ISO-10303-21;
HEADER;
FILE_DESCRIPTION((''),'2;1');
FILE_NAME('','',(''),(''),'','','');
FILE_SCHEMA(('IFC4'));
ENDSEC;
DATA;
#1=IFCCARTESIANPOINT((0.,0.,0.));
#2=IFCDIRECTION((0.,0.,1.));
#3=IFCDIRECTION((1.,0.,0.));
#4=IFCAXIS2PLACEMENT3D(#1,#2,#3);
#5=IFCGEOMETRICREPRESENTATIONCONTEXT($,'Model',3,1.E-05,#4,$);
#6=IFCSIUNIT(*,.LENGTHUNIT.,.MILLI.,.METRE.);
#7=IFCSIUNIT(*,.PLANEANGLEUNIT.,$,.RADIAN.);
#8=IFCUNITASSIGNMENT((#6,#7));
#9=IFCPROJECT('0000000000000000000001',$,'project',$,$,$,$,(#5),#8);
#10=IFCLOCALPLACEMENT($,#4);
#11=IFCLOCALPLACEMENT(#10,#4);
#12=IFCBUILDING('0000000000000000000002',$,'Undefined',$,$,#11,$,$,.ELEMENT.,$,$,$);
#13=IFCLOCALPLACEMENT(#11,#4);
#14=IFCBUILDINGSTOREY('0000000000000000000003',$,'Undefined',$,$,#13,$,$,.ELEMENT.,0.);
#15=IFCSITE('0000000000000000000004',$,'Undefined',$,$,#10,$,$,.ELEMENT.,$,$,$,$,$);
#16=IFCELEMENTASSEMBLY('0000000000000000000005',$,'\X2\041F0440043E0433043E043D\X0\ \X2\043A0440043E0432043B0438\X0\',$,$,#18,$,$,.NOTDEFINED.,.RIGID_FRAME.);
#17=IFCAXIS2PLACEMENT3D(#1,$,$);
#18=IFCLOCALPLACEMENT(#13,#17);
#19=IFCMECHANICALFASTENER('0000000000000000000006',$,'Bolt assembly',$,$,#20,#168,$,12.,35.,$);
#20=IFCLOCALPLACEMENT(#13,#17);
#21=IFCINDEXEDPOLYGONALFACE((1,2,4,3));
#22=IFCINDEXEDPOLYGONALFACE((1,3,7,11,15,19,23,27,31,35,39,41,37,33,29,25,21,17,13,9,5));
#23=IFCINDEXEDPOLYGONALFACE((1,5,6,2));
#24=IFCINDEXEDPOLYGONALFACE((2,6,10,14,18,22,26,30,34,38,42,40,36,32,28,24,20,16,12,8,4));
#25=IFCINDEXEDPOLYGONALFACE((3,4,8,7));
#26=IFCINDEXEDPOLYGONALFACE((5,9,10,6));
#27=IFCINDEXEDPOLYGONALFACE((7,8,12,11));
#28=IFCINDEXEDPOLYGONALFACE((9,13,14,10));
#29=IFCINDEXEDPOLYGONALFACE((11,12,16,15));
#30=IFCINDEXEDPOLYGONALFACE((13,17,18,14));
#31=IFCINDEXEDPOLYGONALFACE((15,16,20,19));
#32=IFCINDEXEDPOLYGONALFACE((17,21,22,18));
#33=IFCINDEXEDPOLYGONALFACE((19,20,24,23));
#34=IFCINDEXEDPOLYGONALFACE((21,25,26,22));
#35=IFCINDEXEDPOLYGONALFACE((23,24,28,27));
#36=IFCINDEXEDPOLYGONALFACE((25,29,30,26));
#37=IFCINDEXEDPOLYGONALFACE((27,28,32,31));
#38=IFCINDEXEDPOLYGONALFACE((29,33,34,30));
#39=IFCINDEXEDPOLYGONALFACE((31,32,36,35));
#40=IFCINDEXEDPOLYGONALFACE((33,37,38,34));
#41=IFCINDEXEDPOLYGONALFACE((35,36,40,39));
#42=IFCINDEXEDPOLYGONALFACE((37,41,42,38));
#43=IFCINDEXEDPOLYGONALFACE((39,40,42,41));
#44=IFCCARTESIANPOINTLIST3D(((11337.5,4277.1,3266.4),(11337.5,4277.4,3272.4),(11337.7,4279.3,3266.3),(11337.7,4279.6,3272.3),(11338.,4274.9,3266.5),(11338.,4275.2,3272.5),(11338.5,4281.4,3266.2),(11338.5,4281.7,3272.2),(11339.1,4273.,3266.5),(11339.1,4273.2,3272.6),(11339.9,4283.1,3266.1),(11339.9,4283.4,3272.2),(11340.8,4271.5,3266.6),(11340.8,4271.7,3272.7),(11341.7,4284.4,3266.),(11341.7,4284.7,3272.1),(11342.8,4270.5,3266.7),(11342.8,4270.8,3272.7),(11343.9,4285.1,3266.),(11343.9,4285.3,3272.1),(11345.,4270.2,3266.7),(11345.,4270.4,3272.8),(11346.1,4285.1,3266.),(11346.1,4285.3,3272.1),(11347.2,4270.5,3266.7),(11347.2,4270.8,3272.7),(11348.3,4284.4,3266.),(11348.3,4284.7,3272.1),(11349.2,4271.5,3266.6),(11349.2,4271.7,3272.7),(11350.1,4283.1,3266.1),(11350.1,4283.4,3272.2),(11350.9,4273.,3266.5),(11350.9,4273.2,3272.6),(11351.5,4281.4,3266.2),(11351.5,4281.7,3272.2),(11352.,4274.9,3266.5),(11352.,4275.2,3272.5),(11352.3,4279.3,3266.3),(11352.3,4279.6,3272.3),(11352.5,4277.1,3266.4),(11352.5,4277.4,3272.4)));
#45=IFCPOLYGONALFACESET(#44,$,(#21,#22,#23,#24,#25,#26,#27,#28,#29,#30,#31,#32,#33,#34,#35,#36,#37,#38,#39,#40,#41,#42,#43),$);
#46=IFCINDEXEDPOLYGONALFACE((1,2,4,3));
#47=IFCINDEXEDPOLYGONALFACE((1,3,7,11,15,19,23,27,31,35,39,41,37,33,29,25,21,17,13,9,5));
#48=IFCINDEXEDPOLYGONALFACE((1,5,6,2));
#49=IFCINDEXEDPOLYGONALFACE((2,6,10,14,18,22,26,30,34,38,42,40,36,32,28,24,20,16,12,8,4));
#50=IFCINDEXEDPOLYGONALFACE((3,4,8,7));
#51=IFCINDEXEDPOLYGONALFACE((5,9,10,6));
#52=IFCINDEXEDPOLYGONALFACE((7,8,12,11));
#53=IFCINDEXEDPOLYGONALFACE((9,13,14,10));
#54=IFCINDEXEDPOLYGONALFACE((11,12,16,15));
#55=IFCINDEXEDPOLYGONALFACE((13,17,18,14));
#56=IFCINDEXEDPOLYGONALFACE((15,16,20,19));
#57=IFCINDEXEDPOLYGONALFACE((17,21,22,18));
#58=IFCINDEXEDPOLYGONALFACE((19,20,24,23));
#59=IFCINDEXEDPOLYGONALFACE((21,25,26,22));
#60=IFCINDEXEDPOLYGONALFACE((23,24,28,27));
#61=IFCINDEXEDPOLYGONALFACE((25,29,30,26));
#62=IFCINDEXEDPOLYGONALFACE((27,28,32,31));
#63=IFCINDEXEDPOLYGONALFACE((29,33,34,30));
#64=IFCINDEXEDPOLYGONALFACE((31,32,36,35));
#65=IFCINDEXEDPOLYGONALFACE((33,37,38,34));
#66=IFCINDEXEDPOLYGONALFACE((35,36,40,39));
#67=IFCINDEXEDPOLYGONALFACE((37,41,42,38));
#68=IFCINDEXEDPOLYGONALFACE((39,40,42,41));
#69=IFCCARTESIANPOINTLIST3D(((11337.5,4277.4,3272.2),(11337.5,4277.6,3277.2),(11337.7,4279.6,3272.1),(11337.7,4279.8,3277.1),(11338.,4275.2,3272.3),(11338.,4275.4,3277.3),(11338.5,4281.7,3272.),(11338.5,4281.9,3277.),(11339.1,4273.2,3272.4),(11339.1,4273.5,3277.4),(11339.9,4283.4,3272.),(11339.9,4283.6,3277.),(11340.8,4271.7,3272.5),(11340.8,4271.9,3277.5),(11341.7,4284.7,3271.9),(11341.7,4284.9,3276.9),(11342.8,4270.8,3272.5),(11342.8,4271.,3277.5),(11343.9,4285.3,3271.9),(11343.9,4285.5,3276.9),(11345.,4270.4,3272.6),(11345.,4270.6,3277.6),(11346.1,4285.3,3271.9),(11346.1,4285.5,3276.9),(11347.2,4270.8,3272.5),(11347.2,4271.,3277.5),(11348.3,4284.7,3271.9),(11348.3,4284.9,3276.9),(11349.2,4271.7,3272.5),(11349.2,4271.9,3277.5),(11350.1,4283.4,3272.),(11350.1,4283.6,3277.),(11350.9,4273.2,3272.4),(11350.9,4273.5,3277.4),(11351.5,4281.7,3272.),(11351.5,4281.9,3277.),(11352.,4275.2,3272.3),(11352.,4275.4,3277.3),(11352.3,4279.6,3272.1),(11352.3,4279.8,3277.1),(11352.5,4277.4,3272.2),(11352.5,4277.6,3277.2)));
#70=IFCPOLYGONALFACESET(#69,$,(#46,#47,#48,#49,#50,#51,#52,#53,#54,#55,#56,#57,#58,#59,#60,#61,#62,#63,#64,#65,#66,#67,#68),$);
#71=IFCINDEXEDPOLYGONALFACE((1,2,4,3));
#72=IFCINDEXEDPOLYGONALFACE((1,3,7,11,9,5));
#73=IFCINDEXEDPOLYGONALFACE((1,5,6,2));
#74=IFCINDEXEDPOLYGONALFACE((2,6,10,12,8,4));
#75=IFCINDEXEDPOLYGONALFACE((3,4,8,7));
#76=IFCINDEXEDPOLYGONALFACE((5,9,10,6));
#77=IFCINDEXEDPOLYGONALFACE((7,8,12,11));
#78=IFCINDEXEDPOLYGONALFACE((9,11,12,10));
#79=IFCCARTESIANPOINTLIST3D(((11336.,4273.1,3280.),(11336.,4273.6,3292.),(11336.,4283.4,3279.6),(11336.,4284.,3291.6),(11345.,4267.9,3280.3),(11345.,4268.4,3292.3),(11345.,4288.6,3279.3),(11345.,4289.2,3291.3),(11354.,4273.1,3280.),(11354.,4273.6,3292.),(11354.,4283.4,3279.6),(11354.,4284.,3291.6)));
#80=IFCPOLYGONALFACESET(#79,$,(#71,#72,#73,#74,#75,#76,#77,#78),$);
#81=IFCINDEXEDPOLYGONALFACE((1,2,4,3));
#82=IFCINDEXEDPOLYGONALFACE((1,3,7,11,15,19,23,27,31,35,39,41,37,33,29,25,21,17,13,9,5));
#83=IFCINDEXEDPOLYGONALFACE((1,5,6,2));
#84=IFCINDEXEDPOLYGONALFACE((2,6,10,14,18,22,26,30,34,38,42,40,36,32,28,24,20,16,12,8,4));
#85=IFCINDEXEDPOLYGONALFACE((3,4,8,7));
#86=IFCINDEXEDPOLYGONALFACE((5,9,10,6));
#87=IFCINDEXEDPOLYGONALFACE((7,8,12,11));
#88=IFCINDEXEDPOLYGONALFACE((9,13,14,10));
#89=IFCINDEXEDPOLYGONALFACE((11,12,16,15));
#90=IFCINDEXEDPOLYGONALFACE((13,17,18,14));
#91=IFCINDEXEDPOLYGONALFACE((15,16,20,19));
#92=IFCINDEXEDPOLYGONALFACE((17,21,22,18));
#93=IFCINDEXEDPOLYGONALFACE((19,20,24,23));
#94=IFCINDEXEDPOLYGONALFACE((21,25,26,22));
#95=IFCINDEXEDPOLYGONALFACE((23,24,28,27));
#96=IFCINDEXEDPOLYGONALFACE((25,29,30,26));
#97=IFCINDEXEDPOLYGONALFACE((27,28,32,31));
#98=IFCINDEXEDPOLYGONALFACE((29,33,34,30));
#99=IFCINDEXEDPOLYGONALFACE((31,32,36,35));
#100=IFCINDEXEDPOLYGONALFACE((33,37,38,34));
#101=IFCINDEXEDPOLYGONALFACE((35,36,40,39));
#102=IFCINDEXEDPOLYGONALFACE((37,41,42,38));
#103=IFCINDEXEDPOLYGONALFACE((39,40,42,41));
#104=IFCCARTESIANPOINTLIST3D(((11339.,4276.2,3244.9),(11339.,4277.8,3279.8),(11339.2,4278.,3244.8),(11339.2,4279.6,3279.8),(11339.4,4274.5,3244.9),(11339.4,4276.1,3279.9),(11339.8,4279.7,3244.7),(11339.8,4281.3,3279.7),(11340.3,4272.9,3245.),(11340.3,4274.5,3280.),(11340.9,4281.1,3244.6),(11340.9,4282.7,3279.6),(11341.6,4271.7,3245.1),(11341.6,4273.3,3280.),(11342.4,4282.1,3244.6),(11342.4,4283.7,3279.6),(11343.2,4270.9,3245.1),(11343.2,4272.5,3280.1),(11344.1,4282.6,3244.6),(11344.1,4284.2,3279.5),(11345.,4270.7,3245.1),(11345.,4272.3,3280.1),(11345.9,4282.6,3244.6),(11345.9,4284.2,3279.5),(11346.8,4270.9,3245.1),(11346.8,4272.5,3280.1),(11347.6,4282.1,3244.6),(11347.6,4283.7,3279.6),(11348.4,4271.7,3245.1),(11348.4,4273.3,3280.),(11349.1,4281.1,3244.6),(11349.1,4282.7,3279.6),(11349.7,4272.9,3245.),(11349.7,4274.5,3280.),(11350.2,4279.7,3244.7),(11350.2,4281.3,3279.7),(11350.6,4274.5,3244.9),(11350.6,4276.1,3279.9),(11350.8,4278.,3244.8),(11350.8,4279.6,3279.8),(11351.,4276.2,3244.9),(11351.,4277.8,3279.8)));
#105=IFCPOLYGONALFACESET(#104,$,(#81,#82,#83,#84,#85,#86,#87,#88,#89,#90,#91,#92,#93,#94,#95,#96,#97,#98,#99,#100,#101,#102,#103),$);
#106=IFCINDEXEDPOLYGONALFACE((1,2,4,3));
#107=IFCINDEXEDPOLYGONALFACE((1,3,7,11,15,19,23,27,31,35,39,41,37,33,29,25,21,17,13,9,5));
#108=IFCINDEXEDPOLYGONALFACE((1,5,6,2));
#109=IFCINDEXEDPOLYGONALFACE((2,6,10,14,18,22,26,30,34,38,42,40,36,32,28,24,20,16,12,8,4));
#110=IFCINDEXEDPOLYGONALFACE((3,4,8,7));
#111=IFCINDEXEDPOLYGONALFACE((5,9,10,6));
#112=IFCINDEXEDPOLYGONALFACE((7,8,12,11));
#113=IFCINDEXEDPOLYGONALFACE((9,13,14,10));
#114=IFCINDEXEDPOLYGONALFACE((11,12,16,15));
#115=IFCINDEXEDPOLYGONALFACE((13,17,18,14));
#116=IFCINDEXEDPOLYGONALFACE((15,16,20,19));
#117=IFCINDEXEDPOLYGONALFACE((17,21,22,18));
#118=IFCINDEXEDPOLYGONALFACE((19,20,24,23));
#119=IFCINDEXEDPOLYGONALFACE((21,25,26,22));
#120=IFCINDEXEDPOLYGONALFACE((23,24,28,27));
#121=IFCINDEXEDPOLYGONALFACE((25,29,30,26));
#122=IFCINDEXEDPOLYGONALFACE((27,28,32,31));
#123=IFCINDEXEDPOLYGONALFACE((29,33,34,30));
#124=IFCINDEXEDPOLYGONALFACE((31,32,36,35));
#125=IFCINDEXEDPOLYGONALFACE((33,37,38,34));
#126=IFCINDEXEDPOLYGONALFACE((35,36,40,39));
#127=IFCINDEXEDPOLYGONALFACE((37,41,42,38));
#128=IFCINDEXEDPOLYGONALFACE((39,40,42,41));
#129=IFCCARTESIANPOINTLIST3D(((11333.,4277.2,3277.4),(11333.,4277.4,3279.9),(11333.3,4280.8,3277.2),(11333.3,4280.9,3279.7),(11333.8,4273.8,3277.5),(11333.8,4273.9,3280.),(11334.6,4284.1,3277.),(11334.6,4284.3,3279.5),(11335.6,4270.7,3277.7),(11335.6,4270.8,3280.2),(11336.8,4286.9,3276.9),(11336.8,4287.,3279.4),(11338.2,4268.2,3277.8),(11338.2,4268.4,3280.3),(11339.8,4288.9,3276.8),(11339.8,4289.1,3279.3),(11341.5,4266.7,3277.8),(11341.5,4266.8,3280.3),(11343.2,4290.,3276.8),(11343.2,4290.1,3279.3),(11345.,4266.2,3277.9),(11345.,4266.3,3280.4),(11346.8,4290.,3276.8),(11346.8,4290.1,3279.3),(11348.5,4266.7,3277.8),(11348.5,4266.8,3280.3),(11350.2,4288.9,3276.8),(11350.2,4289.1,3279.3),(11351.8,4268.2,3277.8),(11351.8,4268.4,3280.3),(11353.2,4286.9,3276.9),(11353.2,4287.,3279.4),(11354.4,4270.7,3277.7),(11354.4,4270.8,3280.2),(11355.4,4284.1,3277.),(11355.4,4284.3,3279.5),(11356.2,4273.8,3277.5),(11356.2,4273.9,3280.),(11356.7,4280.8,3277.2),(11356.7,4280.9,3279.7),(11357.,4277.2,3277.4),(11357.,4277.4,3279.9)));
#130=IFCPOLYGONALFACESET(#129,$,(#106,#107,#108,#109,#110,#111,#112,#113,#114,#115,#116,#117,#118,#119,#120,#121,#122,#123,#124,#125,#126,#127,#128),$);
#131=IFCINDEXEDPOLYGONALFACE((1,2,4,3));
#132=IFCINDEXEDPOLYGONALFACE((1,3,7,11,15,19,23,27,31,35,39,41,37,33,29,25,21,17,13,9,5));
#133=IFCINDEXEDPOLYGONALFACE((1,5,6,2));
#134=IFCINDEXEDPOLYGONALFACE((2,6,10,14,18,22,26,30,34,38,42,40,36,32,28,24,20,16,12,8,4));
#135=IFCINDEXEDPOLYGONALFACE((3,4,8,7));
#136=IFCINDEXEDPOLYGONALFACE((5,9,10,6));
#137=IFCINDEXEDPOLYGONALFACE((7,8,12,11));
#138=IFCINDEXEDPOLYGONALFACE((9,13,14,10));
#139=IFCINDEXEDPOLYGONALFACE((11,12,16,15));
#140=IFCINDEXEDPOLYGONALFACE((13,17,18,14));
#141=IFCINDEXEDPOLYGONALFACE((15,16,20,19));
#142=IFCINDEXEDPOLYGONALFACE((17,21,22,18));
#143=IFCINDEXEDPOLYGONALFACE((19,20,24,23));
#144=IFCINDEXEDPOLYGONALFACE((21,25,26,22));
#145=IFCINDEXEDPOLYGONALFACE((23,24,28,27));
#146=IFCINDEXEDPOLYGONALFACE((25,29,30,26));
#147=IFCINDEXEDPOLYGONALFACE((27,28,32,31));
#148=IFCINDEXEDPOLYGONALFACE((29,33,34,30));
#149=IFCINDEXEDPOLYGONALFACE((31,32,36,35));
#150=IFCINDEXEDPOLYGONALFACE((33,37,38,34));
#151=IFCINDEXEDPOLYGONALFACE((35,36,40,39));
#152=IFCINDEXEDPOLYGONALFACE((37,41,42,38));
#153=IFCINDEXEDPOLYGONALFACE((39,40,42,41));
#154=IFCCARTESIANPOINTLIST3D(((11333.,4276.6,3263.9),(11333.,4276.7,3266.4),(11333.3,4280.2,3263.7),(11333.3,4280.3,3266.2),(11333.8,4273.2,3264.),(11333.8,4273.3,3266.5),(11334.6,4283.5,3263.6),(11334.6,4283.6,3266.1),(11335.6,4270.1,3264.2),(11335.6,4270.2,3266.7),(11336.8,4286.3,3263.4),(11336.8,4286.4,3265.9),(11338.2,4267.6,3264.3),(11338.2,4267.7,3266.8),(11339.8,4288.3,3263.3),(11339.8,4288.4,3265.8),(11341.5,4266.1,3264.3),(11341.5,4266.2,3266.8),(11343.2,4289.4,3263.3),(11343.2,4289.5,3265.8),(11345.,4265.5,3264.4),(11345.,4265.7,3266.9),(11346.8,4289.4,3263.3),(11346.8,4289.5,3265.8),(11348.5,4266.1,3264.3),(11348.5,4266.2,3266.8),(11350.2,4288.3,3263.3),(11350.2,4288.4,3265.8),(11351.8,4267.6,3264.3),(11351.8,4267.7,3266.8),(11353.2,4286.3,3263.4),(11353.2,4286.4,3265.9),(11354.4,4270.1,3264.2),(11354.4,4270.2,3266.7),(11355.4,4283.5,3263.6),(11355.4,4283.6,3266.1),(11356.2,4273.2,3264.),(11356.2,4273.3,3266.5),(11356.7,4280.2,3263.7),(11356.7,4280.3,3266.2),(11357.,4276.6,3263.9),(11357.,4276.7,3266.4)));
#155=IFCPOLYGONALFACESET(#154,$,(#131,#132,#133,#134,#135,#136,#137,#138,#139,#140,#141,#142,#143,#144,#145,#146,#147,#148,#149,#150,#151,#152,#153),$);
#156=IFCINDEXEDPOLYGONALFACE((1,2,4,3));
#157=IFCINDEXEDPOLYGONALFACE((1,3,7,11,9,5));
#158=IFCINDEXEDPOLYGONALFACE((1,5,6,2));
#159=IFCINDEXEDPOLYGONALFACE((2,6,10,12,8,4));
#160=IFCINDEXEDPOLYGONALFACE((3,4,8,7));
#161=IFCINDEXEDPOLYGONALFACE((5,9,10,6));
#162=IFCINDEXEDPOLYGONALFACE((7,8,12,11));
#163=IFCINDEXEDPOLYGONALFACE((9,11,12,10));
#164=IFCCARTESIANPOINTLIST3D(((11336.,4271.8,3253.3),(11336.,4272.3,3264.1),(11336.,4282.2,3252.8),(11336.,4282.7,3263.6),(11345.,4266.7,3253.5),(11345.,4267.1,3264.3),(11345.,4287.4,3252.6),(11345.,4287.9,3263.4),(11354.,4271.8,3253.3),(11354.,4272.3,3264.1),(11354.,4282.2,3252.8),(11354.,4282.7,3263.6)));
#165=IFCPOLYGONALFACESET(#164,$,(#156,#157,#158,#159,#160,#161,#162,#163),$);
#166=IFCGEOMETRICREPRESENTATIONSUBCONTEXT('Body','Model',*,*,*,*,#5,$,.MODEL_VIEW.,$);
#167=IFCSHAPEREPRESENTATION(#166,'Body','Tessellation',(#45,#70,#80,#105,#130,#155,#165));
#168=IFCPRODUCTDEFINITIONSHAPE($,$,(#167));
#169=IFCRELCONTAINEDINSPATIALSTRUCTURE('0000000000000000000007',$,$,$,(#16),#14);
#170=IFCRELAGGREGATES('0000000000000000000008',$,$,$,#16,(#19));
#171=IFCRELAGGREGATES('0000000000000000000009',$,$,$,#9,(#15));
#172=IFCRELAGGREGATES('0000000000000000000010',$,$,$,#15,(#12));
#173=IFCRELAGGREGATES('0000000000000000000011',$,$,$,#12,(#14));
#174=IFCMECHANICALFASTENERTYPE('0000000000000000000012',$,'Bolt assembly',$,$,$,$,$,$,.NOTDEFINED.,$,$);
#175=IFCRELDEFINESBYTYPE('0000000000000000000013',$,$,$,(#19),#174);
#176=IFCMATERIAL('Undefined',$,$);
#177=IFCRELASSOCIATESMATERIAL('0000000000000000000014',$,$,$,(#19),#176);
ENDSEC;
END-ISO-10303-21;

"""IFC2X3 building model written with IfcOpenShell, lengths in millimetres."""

from ifc_helpers import new_model, si_unit, frame, origin_with_axes, origin_2d_with_axis, place, context, subcontext, project, spatial, polyline, circle, outline, extrude, source, transform, mapped, material, type_object, element, aggregate, save


model = new_model("IFC2X3")

# Units and contexts
model_context = context("Model", 3, precision=1e-05, world=origin_with_axes())
body_context = subcontext(model_context, "Body", "Model", "MODEL_VIEW")
ifc_project = project(units=[si_unit("LENGTHUNIT", "METRE", prefix="MILLI"), si_unit("PLANEANGLEUNIT", "RADIAN")], contexts=[model_context])

# Site, building, storey
site_placement = place(None, origin_with_axes())
site = spatial("IfcSite", under=ifc_project, at=site_placement, Name="Undefined", CompositionType="ELEMENT")
building_placement = place(site_placement, origin_with_axes())
building = spatial("IfcBuilding", under=site, at=building_placement, Name="Undefined", CompositionType="ELEMENT")
storey_placement = place(building_placement, origin_with_axes())
storey = spatial("IfcBuildingStorey", under=building, at=storey_placement, Name="Undefined", CompositionType="ELEMENT", Elevation=0.0)

# Element assembly
assembly_1_placement = place(storey_placement, origin_with_axes())
assembly_1 = element("IfcElementAssembly", 1, at=assembly_1_placement, inside=storey, Name="Прогон кровли", AssemblyPlace="NOTDEFINED", PredefinedType="RIGID_FRAME")

# Mechanical fastener
ifc_material_1 = material(Name="Undefined")
mechanical_fastener_type = type_object("IfcMechanicalFastenerType", Name="Bolt assembly")
shared_shape_1 = source(origin_with_axes(), body_context, "Body", "SweptSolid", [
    extrude(circle(Radius=7.5, at=origin_2d_with_axis()), frame((0.0, -0.1, 0.0), z_axis=(0.0, 1.0, 0.0), x_axis=(1.0, 0.0, 0.0)), (0.0, 0.0, 1.0), 6.1),
    extrude(circle(Radius=7.5, at=origin_2d_with_axis()), frame((0.0, -4.9, 0.0), z_axis=(0.0, 1.0, 0.0), x_axis=(1.0, 0.0, 0.0)), (0.0, 0.0, 1.0), 5.0),
    extrude(outline(polyline([(10.4, 0.0), (5.2, 9.0), (-5.2, 9.0), (-10.4, 0.0), (-5.2, -9.0), (5.2, -9.0), (10.4, 0.0)])), frame((0.0, -19.5, 0.0), z_axis=(0.0, 1.0, 0.0), x_axis=(1.0, 0.0, 0.0)), (0.0, 0.0, 1.0), 12.0),
    extrude(circle(Radius=6.0, at=origin_2d_with_axis()), frame((0.0, -7.5, 0.0), z_axis=(0.0, 1.0, 0.0), x_axis=(1.0, 0.0, 0.0)), (0.0, 0.0, 1.0), 35.0),
    extrude(circle(Radius=12.0, at=origin_2d_with_axis()), frame((0.0, -7.5, 0.0), z_axis=(0.0, 1.0, 0.0), x_axis=(1.0, 0.0, 0.0)), (0.0, 0.0, 1.0), 2.5),
    extrude(circle(Radius=12.0, at=origin_2d_with_axis()), frame((0.0, 6.0, 0.0), z_axis=(0.0, 1.0, 0.0), x_axis=(1.0, 0.0, 0.0)), (0.0, 0.0, 1.0), 2.5),
    extrude(outline(polyline([(10.4, 0.0), (5.2, 9.0), (-5.2, 9.0), (-10.4, 0.0), (-5.2, -9.0), (5.2, -9.0), (10.4, 0.0)])), frame((0.0, 8.5, 0.0), z_axis=(0.0, 1.0, 0.0), x_axis=(1.0, 0.0, 0.0)), (0.0, 0.0, 1.0), 10.8),
])
mechanical_fastener_1_placement = place(assembly_1_placement, frame((11345.0, 4277.9, 3272.3), z_axis=(1.0, 0.0, 0.0), x_axis=(0.0, -0.998969, 0.045408)))
mechanical_fastener_1 = element("IfcMechanicalFastener", 2, at=mechanical_fastener_1_placement, type_object=mechanical_fastener_type, material=ifc_material_1, Name="Bolt assembly", NominalDiameter=12.0, NominalLength=35.0, context=body_context, shape_type="MappedRepresentation", body=[
    mapped(shared_shape_1, transform((0.0, 0.0, 0.0))),
])
aggregate(assembly_1, [mechanical_fastener_1])

save(model, "model.ifc")
